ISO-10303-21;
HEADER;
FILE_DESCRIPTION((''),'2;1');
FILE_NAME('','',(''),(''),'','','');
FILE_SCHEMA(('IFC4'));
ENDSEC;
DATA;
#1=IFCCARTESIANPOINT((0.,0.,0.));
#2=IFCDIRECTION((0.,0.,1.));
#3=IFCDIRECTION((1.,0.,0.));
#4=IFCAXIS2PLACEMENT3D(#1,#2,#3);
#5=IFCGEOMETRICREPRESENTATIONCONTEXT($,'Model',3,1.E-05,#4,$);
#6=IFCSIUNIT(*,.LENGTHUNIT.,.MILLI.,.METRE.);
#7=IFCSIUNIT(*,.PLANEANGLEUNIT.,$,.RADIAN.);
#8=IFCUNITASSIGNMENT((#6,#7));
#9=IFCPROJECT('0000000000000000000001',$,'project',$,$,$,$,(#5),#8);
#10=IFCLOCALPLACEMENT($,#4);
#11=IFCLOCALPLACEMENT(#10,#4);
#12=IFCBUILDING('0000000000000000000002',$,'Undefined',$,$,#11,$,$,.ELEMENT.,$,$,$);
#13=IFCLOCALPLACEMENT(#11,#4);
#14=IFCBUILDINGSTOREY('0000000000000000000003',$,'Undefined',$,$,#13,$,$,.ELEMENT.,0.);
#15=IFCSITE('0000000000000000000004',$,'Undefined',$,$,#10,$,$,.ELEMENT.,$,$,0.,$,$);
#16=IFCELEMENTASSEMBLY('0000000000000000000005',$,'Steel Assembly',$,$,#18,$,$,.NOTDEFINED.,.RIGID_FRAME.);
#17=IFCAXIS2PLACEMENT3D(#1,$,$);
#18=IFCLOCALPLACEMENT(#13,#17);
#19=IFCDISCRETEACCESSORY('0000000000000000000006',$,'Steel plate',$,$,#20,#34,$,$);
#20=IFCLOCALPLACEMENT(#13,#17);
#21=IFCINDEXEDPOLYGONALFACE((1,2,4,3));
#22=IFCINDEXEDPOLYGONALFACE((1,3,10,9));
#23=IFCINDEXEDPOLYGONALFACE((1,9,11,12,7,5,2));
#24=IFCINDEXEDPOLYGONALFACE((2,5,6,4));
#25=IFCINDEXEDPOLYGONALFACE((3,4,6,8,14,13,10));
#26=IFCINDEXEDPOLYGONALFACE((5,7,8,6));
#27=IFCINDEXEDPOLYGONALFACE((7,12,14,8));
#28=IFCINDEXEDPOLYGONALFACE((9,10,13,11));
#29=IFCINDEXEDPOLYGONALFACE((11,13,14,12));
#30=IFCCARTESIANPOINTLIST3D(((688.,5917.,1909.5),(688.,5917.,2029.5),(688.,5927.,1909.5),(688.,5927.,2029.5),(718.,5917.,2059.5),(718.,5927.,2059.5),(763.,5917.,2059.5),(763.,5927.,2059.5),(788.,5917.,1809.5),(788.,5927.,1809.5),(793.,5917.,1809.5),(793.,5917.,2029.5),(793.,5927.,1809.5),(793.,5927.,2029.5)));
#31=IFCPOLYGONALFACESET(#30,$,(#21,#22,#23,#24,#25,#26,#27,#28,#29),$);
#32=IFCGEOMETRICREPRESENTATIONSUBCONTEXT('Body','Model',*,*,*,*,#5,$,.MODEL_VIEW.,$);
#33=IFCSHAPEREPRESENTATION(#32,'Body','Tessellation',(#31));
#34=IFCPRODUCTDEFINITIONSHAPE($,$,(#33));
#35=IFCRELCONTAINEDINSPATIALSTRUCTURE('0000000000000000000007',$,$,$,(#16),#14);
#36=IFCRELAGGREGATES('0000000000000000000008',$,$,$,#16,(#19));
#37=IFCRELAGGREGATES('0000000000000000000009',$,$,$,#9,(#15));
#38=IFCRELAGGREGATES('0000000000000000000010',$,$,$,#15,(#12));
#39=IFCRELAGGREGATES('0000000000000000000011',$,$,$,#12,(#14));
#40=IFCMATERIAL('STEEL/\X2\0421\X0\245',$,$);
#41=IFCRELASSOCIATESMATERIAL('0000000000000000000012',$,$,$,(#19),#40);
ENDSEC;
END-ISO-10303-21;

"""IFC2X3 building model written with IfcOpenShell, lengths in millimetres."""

from ifc_helpers import new_model, si_unit, frame, origin_with_axes, place, context, subcontext, project, spatial, polyline, outline, extrude, material, element, aggregate, save


model = new_model("IFC2X3")

# Units and contexts
model_context = context("Model", 3, precision=1e-05, world=origin_with_axes())
body_context = subcontext(model_context, "Body", "Model", "MODEL_VIEW")
ifc_project = project(units=[si_unit("LENGTHUNIT", "METRE", prefix="MILLI"), si_unit("PLANEANGLEUNIT", "RADIAN")], contexts=[model_context])

# Site, building, storey
site_placement = place(None, origin_with_axes())
site = spatial("IfcSite", under=ifc_project, at=site_placement, Name="Undefined", CompositionType="ELEMENT", RefElevation=0.0)
building_placement = place(site_placement, origin_with_axes())
building = spatial("IfcBuilding", under=site, at=building_placement, Name="Undefined", CompositionType="ELEMENT")
storey_placement = place(building_placement, origin_with_axes())
storey = spatial("IfcBuildingStorey", under=building, at=storey_placement, Name="Undefined", CompositionType="ELEMENT", Elevation=0.0)

# Element assembly
assembly_1_placement = place(storey_placement, origin_with_axes())
assembly_1 = element("IfcElementAssembly", 1, at=assembly_1_placement, inside=storey, Name="Steel Assembly", AssemblyPlace="NOTDEFINED", PredefinedType="RIGID_FRAME")
ifc_material_1 = material(Name="STEEL/С245")

# Discrete accessory
discrete_accessory_1_placement = place(assembly_1_placement, frame((793.0, 5922.0, 2059.5), z_axis=(0.0, -1.0, 0.0), x_axis=(-1.0, 0.0, 0.0)))
discrete_accessory_1 = element("IfcDiscreteAccessory", 2, at=discrete_accessory_1_placement, material=ifc_material_1, Name="Steel plate", context=body_context, shape_type="SweptSolid", body=[
    extrude(outline(polyline([(0.0, 30.0), (30.0, 0.0), (75.0, 0.0), (105.0, 30.0), (105.0, 150.0), (5.0, 250.0), (0.0, 250.0), (0.0, 30.0)])), frame((0.0, 0.0, -5.0), z_axis=(0.0, 0.0, 1.0), x_axis=(1.0, 0.0, 0.0)), (0.0, 0.0, 1.0), 10.0),
])
aggregate(assembly_1, [discrete_accessory_1])

save(model, "model.ifc")
